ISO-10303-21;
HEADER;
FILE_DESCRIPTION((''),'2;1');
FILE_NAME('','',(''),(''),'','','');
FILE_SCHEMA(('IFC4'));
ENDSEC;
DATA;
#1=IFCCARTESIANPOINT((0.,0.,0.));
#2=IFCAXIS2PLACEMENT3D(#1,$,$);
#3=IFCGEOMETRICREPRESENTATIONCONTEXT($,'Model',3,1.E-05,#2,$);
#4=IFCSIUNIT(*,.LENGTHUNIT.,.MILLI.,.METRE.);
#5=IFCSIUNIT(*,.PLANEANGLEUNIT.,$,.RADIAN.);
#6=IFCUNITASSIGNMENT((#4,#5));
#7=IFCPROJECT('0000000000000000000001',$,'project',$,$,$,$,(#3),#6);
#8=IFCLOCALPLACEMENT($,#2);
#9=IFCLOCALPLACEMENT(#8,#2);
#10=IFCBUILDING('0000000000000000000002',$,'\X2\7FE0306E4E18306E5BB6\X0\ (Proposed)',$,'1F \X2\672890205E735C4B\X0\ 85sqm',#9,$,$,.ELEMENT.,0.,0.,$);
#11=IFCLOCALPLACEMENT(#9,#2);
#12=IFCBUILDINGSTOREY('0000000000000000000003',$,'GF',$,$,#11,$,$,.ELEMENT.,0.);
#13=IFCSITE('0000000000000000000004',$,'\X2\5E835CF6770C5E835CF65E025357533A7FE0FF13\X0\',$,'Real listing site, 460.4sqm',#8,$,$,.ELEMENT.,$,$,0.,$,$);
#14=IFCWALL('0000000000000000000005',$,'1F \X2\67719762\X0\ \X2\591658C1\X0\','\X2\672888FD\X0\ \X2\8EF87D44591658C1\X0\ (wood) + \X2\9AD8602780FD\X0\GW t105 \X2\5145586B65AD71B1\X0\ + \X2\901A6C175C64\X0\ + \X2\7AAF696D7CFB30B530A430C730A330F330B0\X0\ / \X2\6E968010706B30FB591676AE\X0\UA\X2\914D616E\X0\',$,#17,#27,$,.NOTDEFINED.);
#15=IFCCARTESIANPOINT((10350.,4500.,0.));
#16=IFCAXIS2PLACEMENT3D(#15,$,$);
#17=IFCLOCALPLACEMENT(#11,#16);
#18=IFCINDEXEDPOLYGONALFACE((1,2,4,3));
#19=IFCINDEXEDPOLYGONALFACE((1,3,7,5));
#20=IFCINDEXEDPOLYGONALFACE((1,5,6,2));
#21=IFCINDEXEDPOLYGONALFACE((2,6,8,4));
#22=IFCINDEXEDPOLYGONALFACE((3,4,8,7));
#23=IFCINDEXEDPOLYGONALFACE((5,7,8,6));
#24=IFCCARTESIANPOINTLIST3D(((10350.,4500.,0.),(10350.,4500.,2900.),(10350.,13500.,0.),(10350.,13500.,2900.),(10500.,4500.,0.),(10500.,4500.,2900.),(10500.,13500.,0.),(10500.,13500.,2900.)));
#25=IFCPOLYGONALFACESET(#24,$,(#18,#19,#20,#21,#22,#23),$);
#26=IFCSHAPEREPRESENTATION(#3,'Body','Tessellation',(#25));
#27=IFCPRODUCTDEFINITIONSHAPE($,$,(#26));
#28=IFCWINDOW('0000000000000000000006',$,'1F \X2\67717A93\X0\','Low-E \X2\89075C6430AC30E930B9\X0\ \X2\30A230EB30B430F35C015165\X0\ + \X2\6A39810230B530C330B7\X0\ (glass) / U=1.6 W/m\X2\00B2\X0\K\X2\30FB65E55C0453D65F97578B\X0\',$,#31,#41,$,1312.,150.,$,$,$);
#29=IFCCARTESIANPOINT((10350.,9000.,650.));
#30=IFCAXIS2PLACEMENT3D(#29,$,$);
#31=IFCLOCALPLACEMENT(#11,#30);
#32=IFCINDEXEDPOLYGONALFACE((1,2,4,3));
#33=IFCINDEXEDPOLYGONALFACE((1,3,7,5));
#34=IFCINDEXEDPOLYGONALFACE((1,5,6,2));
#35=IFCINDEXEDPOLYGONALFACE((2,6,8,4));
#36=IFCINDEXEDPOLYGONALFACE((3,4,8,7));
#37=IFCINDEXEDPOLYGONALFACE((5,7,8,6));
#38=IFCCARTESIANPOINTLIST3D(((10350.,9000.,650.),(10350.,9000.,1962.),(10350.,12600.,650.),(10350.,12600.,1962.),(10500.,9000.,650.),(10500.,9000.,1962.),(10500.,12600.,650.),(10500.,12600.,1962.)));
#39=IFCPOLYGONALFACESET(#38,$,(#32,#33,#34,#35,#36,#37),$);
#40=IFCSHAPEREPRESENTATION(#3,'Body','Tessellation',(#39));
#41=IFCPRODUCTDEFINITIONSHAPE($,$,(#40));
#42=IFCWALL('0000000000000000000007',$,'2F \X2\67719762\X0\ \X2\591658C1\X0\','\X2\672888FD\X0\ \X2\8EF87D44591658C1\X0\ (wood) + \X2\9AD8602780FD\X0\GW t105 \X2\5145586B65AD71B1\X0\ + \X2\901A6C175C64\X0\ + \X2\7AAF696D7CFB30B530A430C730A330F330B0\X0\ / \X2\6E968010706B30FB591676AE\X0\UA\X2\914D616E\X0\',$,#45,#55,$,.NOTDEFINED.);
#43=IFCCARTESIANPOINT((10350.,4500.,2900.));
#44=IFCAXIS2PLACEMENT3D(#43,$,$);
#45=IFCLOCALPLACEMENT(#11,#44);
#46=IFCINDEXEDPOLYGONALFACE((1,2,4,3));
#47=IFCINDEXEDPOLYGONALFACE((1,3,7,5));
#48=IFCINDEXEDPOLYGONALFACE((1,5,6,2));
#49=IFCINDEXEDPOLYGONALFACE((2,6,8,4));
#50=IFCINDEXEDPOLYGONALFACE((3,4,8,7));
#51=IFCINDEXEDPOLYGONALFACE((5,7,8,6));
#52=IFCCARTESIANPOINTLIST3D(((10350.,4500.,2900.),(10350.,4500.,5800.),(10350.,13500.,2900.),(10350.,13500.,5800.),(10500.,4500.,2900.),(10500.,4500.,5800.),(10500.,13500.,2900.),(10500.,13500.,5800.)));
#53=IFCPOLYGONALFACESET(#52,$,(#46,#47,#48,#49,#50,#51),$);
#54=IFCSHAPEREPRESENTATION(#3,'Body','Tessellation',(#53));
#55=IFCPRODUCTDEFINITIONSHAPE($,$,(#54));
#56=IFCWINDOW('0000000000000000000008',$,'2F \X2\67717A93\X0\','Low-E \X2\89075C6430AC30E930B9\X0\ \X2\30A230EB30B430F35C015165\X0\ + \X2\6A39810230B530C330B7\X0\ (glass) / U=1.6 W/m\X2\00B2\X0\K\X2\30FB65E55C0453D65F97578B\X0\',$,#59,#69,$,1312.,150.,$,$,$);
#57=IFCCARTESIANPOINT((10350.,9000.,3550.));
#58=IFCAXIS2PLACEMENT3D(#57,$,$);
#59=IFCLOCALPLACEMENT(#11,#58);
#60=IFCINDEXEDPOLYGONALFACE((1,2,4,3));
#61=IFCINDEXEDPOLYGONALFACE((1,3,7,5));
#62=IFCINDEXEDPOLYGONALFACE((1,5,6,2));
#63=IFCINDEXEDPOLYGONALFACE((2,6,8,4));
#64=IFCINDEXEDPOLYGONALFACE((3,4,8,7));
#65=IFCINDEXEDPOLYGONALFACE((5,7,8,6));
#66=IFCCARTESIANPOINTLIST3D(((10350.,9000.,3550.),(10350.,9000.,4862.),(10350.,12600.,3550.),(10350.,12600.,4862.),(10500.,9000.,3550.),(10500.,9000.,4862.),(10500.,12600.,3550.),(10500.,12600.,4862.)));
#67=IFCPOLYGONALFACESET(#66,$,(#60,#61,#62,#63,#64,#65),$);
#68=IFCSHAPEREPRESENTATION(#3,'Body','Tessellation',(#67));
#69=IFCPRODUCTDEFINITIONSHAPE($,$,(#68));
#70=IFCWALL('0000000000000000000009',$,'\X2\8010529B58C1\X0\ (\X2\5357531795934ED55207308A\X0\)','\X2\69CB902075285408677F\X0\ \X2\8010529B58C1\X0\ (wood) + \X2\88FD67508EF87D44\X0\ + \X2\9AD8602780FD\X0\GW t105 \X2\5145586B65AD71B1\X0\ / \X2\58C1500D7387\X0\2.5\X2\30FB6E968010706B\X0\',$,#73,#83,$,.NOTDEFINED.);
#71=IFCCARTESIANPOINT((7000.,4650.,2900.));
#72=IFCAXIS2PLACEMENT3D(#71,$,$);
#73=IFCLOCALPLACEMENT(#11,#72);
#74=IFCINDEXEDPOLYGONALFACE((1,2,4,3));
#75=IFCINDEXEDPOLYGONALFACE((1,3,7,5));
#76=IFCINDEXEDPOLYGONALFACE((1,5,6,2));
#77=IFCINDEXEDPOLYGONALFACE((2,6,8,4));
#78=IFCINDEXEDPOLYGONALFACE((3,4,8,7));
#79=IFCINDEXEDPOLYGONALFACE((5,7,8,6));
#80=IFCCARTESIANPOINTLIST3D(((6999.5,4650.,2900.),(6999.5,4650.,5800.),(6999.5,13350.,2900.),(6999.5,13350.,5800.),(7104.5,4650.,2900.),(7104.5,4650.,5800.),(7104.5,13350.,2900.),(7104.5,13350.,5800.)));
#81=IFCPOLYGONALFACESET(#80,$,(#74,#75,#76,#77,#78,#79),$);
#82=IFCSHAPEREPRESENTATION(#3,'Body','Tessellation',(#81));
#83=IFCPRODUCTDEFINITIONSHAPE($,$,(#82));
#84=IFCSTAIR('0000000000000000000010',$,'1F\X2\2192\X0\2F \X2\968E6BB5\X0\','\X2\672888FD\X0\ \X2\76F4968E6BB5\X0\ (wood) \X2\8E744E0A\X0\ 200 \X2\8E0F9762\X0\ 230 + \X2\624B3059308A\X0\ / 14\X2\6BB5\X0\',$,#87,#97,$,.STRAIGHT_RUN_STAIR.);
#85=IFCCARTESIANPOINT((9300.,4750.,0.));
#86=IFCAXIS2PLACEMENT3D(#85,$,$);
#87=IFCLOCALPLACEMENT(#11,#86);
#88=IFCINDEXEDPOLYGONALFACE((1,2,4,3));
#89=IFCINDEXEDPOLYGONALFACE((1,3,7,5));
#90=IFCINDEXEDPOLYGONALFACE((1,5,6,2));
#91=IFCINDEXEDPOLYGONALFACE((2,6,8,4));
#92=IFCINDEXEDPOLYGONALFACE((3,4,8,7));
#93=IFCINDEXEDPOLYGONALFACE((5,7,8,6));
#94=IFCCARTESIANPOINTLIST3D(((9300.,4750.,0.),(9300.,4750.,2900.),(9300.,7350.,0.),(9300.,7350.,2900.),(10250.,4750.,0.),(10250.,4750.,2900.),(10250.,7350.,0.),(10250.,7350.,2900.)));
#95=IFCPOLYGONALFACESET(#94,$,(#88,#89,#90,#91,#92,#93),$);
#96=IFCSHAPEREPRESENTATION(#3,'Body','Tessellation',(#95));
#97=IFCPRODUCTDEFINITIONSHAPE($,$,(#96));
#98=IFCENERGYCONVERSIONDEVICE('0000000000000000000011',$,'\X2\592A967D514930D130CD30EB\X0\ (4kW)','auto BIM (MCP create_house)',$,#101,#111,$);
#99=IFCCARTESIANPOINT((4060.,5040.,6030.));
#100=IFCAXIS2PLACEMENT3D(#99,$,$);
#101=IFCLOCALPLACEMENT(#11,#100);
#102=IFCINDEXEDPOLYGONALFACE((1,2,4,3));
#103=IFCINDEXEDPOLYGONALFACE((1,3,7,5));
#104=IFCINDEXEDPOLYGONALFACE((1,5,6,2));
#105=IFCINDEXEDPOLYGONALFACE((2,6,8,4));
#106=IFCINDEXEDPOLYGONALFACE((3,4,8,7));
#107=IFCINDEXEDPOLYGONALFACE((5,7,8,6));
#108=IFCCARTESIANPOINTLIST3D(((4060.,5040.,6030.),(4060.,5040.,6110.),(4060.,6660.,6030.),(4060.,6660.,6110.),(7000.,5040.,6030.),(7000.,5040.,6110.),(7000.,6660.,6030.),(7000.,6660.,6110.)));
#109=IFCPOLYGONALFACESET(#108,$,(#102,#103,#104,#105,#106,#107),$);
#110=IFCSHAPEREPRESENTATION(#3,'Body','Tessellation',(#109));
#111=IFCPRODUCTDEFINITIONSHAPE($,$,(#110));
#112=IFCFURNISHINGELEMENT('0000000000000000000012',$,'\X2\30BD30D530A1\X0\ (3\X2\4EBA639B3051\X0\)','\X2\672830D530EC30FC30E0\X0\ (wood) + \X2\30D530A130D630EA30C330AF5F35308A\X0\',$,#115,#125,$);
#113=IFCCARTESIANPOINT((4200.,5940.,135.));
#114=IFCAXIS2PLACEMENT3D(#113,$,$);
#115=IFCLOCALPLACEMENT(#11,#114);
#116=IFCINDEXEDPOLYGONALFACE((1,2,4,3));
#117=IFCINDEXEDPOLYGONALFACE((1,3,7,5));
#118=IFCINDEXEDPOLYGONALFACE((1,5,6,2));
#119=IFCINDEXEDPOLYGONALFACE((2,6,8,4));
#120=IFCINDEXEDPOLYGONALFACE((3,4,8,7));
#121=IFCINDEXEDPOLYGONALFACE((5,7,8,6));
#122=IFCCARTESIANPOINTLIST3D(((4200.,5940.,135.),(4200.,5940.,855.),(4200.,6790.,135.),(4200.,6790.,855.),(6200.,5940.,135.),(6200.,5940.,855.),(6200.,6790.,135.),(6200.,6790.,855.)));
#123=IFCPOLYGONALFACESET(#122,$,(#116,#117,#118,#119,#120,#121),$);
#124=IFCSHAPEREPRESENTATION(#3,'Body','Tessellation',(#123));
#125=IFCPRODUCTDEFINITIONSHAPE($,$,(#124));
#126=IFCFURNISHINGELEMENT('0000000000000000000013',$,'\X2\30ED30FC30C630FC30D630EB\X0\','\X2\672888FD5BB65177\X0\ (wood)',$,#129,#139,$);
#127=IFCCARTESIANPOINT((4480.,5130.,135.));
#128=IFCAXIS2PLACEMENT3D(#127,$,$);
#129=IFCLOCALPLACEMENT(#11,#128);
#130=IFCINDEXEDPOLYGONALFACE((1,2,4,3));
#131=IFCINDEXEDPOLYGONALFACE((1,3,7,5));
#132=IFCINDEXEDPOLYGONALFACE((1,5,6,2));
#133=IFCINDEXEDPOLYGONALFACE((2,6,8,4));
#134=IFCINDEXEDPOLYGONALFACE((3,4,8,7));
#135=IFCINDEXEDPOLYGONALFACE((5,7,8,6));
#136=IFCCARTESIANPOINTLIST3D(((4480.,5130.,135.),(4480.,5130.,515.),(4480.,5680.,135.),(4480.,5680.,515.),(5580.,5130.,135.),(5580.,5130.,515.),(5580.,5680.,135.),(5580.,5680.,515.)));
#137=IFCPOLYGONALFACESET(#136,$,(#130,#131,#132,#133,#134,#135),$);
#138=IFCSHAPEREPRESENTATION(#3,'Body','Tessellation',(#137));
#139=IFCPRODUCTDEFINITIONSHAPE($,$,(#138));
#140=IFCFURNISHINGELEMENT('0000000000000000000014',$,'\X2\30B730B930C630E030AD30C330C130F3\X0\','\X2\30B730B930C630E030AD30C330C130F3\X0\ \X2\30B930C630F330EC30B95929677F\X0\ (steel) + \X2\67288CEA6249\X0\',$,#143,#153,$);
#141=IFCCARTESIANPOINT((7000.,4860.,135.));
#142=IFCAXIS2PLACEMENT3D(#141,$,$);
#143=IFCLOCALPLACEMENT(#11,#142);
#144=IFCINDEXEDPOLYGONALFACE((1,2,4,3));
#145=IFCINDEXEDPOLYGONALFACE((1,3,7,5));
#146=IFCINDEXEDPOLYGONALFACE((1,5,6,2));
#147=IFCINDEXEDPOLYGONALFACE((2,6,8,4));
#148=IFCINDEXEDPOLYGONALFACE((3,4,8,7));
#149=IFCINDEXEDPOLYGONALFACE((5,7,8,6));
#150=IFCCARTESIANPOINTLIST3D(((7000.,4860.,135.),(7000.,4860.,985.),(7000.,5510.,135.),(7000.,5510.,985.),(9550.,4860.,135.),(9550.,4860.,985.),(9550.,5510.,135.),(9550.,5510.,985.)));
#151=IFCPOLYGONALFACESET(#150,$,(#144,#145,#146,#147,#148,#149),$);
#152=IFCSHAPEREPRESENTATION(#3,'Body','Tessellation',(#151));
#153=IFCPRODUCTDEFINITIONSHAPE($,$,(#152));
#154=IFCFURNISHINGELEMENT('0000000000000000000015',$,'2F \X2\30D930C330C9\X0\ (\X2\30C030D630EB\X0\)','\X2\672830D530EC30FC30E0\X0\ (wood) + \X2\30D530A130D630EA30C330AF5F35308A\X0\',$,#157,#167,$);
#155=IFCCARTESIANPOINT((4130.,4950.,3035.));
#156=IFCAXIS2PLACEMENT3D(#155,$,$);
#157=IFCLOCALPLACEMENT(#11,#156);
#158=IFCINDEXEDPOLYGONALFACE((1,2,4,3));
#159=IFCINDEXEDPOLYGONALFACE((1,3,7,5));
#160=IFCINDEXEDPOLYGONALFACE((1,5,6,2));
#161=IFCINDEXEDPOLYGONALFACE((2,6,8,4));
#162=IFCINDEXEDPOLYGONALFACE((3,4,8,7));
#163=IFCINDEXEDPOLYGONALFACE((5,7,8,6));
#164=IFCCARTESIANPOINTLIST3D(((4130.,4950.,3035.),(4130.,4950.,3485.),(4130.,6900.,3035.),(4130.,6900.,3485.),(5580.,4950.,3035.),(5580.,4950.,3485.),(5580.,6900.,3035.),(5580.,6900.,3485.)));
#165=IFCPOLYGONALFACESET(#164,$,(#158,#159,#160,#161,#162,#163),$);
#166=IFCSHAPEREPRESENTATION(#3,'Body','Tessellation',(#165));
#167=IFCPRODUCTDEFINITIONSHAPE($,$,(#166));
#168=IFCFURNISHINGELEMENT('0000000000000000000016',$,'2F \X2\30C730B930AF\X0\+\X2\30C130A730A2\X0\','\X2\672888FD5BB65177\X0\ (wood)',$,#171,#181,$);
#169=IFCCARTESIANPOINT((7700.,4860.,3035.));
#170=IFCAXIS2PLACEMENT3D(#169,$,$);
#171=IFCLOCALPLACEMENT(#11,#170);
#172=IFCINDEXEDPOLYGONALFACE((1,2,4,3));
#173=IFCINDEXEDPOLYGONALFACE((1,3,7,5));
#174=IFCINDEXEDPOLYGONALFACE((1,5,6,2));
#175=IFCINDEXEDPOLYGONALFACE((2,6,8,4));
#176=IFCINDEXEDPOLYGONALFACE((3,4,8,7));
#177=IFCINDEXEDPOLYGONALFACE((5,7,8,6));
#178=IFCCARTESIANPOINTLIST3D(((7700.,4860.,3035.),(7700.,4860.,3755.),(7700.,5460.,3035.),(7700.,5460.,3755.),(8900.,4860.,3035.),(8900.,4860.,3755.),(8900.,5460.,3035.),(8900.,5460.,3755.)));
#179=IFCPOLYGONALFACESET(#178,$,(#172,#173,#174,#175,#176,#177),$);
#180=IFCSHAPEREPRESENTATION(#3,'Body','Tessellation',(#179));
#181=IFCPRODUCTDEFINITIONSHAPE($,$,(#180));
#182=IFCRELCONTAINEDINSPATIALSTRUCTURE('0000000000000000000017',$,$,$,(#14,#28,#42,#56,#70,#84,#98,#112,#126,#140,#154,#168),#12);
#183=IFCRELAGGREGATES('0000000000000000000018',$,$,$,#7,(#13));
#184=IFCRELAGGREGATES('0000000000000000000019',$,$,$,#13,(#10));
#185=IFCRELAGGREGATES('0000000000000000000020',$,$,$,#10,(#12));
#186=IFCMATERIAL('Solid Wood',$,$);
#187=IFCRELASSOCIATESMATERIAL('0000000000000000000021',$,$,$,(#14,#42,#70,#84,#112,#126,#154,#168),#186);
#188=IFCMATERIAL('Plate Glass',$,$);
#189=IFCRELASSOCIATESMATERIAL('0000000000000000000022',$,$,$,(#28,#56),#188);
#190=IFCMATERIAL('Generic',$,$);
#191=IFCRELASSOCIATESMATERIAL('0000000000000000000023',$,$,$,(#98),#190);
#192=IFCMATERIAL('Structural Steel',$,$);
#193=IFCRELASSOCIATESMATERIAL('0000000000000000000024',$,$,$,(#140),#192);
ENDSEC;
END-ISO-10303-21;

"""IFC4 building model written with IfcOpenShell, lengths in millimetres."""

from ifc_helpers import new_model, si_unit, frame, frame_2d, origin, place, context, project, spatial, rectangle, extrude, material, element, fill, save


model = new_model("IFC4")

# Units and contexts
model_context = context("Model", 3, precision=1e-05, world=origin())
ifc_project = project(units=[si_unit("LENGTHUNIT", "METRE", prefix="MILLI"), si_unit("PLANEANGLEUNIT", "RADIAN")], contexts=[model_context])

# Site, building, storey
site_placement = place(None, origin())
site = spatial("IfcSite", under=ifc_project, at=site_placement, Name="広島県広島市南区翠３", ObjectType="Real listing site, 460.4sqm", CompositionType="ELEMENT", RefElevation=0.0)
building_placement = place(site_placement, origin())
building = spatial("IfcBuilding", under=site, at=building_placement, Name="翠の丘の家 (Proposed)", ObjectType="1F 木造平屋 85sqm", CompositionType="ELEMENT", ElevationOfRefHeight=0.0, ElevationOfTerrain=0.0)
storey_placement = place(building_placement, origin())
storey = spatial("IfcBuildingStorey", under=building, at=storey_placement, Name="GF", CompositionType="ELEMENT", Elevation=0.0)

# Wall, opening, window
ifc_material_1 = material(Name="Solid Wood")
wall_1_placement = place(storey_placement, frame((10350.0, 4500.0, 0.0)))
wall_1 = element("IfcWall", 1, at=wall_1_placement, inside=storey, material=ifc_material_1, Name="1F 東面 外壁", Description="木製 軸組外壁 (wood) + 高性能GW t105 充填断熱 + 通気層 + 窯業系サイディング / 準耐火・外皮UA配慮", PredefinedType="NOTDEFINED", context=model_context, shape_type="SweptSolid", body=[
    extrude(rectangle(XDim=150.0, YDim=9000.0, at=frame_2d((75.0, 4500.0))), frame((10350.0, 4500.0, 0.0)), (0.0, 0.0, 1.0), 2900.0),
])
opening_1_placement = place(storey_placement, frame((10350.0, 9000.0, 650.0)))
opening_1 = element("IfcOpeningElement", 2, at=opening_1_placement, cuts=wall_1, PredefinedType="NOTDEFINED", context=model_context, shape_type="SweptSolid", body=[
    extrude(rectangle(XDim=150.0, YDim=3600.0, at=frame_2d((75.0, 1800.0))), frame((10350.0, 9000.0, 650.0)), (0.0, 0.0, 1.0), 1312.0),
])
ifc_material_2 = material(Name="Plate Glass")
window_1_placement = place(storey_placement, frame((10350.0, 9000.0, 650.0)))
window_1 = element("IfcWindow", 3, at=window_1_placement, inside=storey, material=ifc_material_2, Name="1F 東窓", Description="Low-E 複層ガラス アルゴン封入 + 樹脂サッシ (glass) / U=1.6 W/m²K・日射取得型", OverallHeight=1312.0, OverallWidth=150.0, context=model_context, shape_type="SweptSolid", body=[
    extrude(rectangle(XDim=150.0, YDim=3600.0, at=frame_2d((75.0, 1800.0))), frame((10350.0, 9000.0, 650.0)), (0.0, 0.0, 1.0), 1312.0),
])
fill(opening_1, window_1)

# Wall, opening, window
wall_2_placement = place(storey_placement, frame((10350.0, 4500.0, 2900.0)))
wall_2 = element("IfcWall", 4, at=wall_2_placement, inside=storey, material=ifc_material_1, Name="2F 東面 外壁", Description="木製 軸組外壁 (wood) + 高性能GW t105 充填断熱 + 通気層 + 窯業系サイディング / 準耐火・外皮UA配慮", PredefinedType="NOTDEFINED", context=model_context, shape_type="SweptSolid", body=[
    extrude(rectangle(XDim=150.0, YDim=9000.0, at=frame_2d((75.0, 4500.0))), frame((10350.0, 4500.0, 2900.0)), (0.0, 0.0, 1.0), 2900.0),
])
opening_2_placement = place(storey_placement, frame((10350.0, 9000.0, 3550.0)))
opening_2 = element("IfcOpeningElement", 5, at=opening_2_placement, cuts=wall_2, PredefinedType="NOTDEFINED", context=model_context, shape_type="SweptSolid", body=[
    extrude(rectangle(XDim=150.0, YDim=3600.0, at=frame_2d((75.0, 1800.0))), frame((10350.0, 9000.0, 3550.0)), (0.0, 0.0, 1.0), 1312.0),
])
window_2_placement = place(storey_placement, frame((10350.0, 9000.0, 3550.0)))
window_2 = element("IfcWindow", 6, at=window_2_placement, inside=storey, material=ifc_material_2, Name="2F 東窓", Description="Low-E 複層ガラス アルゴン封入 + 樹脂サッシ (glass) / U=1.6 W/m²K・日射取得型", OverallHeight=1312.0, OverallWidth=150.0, context=model_context, shape_type="SweptSolid", body=[
    extrude(rectangle(XDim=150.0, YDim=3600.0, at=frame_2d((75.0, 1800.0))), frame((10350.0, 9000.0, 3550.0)), (0.0, 0.0, 1.0), 1312.0),
])
fill(opening_2, window_2)

# Wall
wall_3_placement = place(storey_placement, frame((7000.0, 4650.0, 2900.0)))
element("IfcWall", 7, at=wall_3_placement, inside=storey, material=ifc_material_1, Name="耐力壁 (南北間仕切り)", Description="構造用合板 耐力壁 (wood) + 製材軸組 + 高性能GW t105 充填断熱 / 壁倍率2.5・準耐火", PredefinedType="NOTDEFINED", context=model_context, shape_type="SweptSolid", body=[
    extrude(rectangle(XDim=105.0, YDim=8700.0, at=frame_2d((52.0, 4350.0))), frame((7000.0, 4650.0, 2900.0)), (0.0, 0.0, 1.0), 2900.0),
])

# Stair
stair_placement = place(storey_placement, frame((9300.0, 4750.0, 0.0)))
element("IfcStair", 8, at=stair_placement, inside=storey, material=ifc_material_1, Name="1F→2F 階段", Description="木製 直階段 (wood) 蹴上 200 踏面 230 + 手すり / 14段", PredefinedType="STRAIGHT_RUN_STAIR", context=model_context, shape_type="SweptSolid", body=[
    extrude(rectangle(XDim=950.0, YDim=2600.0, at=frame_2d((475.0, 1300.0))), frame((9300.0, 4750.0, 0.0)), (0.0, 0.0, 1.0), 2900.0),
])

# Energy conversion device
ifc_material_3 = material(Name="Generic")
energy_conversion_device_placement = place(storey_placement, frame((4060.0, 5040.0, 6030.0)))
element("IfcEnergyConversionDevice", 9, at=energy_conversion_device_placement, inside=storey, material=ifc_material_3, Name="太陽光パネル (4kW)", Description="auto BIM (MCP create_house)", context=model_context, shape_type="SweptSolid", body=[
    extrude(rectangle(XDim=2940.0, YDim=1620.0, at=frame_2d((1470.0, 810.0))), frame((4060.0, 5040.0, 6030.0)), (0.0, 0.0, 1.0), 80.0),
])

# Furnishing elements
furnishing_1_placement = place(storey_placement, frame((4200.0, 5940.0, 135.0)))
element("IfcFurnishingElement", 10, at=furnishing_1_placement, inside=storey, material=ifc_material_1, Name="ソファ (3人掛け)", Description="木フレーム (wood) + ファブリック張り", context=model_context, shape_type="SweptSolid", body=[
    extrude(rectangle(XDim=2000.0, YDim=850.0, at=frame_2d((1000.0, 425.0))), frame((4200.0, 5940.0, 135.0)), (0.0, 0.0, 1.0), 720.0),
])
furnishing_2_placement = place(storey_placement, frame((4480.0, 5130.0, 135.0)))
element("IfcFurnishingElement", 11, at=furnishing_2_placement, inside=storey, material=ifc_material_1, Name="ローテーブル", Description="木製家具 (wood)", context=model_context, shape_type="SweptSolid", body=[
    extrude(rectangle(XDim=1100.0, YDim=550.0, at=frame_2d((550.0, 275.0))), frame((4480.0, 5130.0, 135.0)), (0.0, 0.0, 1.0), 380.0),
])
ifc_material_4 = material(Name="Structural Steel")
furnishing_3_placement = place(storey_placement, frame((7000.0, 4860.0, 135.0)))
element("IfcFurnishingElement", 12, at=furnishing_3_placement, inside=storey, material=ifc_material_4, Name="システムキッチン", Description="システムキッチン ステンレス天板 (steel) + 木質扉", context=model_context, shape_type="SweptSolid", body=[
    extrude(rectangle(XDim=2550.0, YDim=650.0, at=frame_2d((1275.0, 325.0))), frame((7000.0, 4860.0, 135.0)), (0.0, 0.0, 1.0), 850.0),
])
furnishing_4_placement = place(storey_placement, frame((4130.0, 4950.0, 3035.0)))
element("IfcFurnishingElement", 13, at=furnishing_4_placement, inside=storey, material=ifc_material_1, Name="2F ベッド (ダブル)", Description="木フレーム (wood) + ファブリック張り", context=model_context, shape_type="SweptSolid", body=[
    extrude(rectangle(XDim=1450.0, YDim=1950.0, at=frame_2d((725.0, 975.0))), frame((4130.0, 4950.0, 3035.0)), (0.0, 0.0, 1.0), 450.0),
])
furnishing_5_placement = place(storey_placement, frame((7700.0, 4860.0, 3035.0)))
element("IfcFurnishingElement", 14, at=furnishing_5_placement, inside=storey, material=ifc_material_1, Name="2F デスク+チェア", Description="木製家具 (wood)", context=model_context, shape_type="SweptSolid", body=[
    extrude(rectangle(XDim=1200.0, YDim=600.0, at=frame_2d((600.0, 300.0))), frame((7700.0, 4860.0, 3035.0)), (0.0, 0.0, 1.0), 720.0),
])

save(model, "model.ifc")
